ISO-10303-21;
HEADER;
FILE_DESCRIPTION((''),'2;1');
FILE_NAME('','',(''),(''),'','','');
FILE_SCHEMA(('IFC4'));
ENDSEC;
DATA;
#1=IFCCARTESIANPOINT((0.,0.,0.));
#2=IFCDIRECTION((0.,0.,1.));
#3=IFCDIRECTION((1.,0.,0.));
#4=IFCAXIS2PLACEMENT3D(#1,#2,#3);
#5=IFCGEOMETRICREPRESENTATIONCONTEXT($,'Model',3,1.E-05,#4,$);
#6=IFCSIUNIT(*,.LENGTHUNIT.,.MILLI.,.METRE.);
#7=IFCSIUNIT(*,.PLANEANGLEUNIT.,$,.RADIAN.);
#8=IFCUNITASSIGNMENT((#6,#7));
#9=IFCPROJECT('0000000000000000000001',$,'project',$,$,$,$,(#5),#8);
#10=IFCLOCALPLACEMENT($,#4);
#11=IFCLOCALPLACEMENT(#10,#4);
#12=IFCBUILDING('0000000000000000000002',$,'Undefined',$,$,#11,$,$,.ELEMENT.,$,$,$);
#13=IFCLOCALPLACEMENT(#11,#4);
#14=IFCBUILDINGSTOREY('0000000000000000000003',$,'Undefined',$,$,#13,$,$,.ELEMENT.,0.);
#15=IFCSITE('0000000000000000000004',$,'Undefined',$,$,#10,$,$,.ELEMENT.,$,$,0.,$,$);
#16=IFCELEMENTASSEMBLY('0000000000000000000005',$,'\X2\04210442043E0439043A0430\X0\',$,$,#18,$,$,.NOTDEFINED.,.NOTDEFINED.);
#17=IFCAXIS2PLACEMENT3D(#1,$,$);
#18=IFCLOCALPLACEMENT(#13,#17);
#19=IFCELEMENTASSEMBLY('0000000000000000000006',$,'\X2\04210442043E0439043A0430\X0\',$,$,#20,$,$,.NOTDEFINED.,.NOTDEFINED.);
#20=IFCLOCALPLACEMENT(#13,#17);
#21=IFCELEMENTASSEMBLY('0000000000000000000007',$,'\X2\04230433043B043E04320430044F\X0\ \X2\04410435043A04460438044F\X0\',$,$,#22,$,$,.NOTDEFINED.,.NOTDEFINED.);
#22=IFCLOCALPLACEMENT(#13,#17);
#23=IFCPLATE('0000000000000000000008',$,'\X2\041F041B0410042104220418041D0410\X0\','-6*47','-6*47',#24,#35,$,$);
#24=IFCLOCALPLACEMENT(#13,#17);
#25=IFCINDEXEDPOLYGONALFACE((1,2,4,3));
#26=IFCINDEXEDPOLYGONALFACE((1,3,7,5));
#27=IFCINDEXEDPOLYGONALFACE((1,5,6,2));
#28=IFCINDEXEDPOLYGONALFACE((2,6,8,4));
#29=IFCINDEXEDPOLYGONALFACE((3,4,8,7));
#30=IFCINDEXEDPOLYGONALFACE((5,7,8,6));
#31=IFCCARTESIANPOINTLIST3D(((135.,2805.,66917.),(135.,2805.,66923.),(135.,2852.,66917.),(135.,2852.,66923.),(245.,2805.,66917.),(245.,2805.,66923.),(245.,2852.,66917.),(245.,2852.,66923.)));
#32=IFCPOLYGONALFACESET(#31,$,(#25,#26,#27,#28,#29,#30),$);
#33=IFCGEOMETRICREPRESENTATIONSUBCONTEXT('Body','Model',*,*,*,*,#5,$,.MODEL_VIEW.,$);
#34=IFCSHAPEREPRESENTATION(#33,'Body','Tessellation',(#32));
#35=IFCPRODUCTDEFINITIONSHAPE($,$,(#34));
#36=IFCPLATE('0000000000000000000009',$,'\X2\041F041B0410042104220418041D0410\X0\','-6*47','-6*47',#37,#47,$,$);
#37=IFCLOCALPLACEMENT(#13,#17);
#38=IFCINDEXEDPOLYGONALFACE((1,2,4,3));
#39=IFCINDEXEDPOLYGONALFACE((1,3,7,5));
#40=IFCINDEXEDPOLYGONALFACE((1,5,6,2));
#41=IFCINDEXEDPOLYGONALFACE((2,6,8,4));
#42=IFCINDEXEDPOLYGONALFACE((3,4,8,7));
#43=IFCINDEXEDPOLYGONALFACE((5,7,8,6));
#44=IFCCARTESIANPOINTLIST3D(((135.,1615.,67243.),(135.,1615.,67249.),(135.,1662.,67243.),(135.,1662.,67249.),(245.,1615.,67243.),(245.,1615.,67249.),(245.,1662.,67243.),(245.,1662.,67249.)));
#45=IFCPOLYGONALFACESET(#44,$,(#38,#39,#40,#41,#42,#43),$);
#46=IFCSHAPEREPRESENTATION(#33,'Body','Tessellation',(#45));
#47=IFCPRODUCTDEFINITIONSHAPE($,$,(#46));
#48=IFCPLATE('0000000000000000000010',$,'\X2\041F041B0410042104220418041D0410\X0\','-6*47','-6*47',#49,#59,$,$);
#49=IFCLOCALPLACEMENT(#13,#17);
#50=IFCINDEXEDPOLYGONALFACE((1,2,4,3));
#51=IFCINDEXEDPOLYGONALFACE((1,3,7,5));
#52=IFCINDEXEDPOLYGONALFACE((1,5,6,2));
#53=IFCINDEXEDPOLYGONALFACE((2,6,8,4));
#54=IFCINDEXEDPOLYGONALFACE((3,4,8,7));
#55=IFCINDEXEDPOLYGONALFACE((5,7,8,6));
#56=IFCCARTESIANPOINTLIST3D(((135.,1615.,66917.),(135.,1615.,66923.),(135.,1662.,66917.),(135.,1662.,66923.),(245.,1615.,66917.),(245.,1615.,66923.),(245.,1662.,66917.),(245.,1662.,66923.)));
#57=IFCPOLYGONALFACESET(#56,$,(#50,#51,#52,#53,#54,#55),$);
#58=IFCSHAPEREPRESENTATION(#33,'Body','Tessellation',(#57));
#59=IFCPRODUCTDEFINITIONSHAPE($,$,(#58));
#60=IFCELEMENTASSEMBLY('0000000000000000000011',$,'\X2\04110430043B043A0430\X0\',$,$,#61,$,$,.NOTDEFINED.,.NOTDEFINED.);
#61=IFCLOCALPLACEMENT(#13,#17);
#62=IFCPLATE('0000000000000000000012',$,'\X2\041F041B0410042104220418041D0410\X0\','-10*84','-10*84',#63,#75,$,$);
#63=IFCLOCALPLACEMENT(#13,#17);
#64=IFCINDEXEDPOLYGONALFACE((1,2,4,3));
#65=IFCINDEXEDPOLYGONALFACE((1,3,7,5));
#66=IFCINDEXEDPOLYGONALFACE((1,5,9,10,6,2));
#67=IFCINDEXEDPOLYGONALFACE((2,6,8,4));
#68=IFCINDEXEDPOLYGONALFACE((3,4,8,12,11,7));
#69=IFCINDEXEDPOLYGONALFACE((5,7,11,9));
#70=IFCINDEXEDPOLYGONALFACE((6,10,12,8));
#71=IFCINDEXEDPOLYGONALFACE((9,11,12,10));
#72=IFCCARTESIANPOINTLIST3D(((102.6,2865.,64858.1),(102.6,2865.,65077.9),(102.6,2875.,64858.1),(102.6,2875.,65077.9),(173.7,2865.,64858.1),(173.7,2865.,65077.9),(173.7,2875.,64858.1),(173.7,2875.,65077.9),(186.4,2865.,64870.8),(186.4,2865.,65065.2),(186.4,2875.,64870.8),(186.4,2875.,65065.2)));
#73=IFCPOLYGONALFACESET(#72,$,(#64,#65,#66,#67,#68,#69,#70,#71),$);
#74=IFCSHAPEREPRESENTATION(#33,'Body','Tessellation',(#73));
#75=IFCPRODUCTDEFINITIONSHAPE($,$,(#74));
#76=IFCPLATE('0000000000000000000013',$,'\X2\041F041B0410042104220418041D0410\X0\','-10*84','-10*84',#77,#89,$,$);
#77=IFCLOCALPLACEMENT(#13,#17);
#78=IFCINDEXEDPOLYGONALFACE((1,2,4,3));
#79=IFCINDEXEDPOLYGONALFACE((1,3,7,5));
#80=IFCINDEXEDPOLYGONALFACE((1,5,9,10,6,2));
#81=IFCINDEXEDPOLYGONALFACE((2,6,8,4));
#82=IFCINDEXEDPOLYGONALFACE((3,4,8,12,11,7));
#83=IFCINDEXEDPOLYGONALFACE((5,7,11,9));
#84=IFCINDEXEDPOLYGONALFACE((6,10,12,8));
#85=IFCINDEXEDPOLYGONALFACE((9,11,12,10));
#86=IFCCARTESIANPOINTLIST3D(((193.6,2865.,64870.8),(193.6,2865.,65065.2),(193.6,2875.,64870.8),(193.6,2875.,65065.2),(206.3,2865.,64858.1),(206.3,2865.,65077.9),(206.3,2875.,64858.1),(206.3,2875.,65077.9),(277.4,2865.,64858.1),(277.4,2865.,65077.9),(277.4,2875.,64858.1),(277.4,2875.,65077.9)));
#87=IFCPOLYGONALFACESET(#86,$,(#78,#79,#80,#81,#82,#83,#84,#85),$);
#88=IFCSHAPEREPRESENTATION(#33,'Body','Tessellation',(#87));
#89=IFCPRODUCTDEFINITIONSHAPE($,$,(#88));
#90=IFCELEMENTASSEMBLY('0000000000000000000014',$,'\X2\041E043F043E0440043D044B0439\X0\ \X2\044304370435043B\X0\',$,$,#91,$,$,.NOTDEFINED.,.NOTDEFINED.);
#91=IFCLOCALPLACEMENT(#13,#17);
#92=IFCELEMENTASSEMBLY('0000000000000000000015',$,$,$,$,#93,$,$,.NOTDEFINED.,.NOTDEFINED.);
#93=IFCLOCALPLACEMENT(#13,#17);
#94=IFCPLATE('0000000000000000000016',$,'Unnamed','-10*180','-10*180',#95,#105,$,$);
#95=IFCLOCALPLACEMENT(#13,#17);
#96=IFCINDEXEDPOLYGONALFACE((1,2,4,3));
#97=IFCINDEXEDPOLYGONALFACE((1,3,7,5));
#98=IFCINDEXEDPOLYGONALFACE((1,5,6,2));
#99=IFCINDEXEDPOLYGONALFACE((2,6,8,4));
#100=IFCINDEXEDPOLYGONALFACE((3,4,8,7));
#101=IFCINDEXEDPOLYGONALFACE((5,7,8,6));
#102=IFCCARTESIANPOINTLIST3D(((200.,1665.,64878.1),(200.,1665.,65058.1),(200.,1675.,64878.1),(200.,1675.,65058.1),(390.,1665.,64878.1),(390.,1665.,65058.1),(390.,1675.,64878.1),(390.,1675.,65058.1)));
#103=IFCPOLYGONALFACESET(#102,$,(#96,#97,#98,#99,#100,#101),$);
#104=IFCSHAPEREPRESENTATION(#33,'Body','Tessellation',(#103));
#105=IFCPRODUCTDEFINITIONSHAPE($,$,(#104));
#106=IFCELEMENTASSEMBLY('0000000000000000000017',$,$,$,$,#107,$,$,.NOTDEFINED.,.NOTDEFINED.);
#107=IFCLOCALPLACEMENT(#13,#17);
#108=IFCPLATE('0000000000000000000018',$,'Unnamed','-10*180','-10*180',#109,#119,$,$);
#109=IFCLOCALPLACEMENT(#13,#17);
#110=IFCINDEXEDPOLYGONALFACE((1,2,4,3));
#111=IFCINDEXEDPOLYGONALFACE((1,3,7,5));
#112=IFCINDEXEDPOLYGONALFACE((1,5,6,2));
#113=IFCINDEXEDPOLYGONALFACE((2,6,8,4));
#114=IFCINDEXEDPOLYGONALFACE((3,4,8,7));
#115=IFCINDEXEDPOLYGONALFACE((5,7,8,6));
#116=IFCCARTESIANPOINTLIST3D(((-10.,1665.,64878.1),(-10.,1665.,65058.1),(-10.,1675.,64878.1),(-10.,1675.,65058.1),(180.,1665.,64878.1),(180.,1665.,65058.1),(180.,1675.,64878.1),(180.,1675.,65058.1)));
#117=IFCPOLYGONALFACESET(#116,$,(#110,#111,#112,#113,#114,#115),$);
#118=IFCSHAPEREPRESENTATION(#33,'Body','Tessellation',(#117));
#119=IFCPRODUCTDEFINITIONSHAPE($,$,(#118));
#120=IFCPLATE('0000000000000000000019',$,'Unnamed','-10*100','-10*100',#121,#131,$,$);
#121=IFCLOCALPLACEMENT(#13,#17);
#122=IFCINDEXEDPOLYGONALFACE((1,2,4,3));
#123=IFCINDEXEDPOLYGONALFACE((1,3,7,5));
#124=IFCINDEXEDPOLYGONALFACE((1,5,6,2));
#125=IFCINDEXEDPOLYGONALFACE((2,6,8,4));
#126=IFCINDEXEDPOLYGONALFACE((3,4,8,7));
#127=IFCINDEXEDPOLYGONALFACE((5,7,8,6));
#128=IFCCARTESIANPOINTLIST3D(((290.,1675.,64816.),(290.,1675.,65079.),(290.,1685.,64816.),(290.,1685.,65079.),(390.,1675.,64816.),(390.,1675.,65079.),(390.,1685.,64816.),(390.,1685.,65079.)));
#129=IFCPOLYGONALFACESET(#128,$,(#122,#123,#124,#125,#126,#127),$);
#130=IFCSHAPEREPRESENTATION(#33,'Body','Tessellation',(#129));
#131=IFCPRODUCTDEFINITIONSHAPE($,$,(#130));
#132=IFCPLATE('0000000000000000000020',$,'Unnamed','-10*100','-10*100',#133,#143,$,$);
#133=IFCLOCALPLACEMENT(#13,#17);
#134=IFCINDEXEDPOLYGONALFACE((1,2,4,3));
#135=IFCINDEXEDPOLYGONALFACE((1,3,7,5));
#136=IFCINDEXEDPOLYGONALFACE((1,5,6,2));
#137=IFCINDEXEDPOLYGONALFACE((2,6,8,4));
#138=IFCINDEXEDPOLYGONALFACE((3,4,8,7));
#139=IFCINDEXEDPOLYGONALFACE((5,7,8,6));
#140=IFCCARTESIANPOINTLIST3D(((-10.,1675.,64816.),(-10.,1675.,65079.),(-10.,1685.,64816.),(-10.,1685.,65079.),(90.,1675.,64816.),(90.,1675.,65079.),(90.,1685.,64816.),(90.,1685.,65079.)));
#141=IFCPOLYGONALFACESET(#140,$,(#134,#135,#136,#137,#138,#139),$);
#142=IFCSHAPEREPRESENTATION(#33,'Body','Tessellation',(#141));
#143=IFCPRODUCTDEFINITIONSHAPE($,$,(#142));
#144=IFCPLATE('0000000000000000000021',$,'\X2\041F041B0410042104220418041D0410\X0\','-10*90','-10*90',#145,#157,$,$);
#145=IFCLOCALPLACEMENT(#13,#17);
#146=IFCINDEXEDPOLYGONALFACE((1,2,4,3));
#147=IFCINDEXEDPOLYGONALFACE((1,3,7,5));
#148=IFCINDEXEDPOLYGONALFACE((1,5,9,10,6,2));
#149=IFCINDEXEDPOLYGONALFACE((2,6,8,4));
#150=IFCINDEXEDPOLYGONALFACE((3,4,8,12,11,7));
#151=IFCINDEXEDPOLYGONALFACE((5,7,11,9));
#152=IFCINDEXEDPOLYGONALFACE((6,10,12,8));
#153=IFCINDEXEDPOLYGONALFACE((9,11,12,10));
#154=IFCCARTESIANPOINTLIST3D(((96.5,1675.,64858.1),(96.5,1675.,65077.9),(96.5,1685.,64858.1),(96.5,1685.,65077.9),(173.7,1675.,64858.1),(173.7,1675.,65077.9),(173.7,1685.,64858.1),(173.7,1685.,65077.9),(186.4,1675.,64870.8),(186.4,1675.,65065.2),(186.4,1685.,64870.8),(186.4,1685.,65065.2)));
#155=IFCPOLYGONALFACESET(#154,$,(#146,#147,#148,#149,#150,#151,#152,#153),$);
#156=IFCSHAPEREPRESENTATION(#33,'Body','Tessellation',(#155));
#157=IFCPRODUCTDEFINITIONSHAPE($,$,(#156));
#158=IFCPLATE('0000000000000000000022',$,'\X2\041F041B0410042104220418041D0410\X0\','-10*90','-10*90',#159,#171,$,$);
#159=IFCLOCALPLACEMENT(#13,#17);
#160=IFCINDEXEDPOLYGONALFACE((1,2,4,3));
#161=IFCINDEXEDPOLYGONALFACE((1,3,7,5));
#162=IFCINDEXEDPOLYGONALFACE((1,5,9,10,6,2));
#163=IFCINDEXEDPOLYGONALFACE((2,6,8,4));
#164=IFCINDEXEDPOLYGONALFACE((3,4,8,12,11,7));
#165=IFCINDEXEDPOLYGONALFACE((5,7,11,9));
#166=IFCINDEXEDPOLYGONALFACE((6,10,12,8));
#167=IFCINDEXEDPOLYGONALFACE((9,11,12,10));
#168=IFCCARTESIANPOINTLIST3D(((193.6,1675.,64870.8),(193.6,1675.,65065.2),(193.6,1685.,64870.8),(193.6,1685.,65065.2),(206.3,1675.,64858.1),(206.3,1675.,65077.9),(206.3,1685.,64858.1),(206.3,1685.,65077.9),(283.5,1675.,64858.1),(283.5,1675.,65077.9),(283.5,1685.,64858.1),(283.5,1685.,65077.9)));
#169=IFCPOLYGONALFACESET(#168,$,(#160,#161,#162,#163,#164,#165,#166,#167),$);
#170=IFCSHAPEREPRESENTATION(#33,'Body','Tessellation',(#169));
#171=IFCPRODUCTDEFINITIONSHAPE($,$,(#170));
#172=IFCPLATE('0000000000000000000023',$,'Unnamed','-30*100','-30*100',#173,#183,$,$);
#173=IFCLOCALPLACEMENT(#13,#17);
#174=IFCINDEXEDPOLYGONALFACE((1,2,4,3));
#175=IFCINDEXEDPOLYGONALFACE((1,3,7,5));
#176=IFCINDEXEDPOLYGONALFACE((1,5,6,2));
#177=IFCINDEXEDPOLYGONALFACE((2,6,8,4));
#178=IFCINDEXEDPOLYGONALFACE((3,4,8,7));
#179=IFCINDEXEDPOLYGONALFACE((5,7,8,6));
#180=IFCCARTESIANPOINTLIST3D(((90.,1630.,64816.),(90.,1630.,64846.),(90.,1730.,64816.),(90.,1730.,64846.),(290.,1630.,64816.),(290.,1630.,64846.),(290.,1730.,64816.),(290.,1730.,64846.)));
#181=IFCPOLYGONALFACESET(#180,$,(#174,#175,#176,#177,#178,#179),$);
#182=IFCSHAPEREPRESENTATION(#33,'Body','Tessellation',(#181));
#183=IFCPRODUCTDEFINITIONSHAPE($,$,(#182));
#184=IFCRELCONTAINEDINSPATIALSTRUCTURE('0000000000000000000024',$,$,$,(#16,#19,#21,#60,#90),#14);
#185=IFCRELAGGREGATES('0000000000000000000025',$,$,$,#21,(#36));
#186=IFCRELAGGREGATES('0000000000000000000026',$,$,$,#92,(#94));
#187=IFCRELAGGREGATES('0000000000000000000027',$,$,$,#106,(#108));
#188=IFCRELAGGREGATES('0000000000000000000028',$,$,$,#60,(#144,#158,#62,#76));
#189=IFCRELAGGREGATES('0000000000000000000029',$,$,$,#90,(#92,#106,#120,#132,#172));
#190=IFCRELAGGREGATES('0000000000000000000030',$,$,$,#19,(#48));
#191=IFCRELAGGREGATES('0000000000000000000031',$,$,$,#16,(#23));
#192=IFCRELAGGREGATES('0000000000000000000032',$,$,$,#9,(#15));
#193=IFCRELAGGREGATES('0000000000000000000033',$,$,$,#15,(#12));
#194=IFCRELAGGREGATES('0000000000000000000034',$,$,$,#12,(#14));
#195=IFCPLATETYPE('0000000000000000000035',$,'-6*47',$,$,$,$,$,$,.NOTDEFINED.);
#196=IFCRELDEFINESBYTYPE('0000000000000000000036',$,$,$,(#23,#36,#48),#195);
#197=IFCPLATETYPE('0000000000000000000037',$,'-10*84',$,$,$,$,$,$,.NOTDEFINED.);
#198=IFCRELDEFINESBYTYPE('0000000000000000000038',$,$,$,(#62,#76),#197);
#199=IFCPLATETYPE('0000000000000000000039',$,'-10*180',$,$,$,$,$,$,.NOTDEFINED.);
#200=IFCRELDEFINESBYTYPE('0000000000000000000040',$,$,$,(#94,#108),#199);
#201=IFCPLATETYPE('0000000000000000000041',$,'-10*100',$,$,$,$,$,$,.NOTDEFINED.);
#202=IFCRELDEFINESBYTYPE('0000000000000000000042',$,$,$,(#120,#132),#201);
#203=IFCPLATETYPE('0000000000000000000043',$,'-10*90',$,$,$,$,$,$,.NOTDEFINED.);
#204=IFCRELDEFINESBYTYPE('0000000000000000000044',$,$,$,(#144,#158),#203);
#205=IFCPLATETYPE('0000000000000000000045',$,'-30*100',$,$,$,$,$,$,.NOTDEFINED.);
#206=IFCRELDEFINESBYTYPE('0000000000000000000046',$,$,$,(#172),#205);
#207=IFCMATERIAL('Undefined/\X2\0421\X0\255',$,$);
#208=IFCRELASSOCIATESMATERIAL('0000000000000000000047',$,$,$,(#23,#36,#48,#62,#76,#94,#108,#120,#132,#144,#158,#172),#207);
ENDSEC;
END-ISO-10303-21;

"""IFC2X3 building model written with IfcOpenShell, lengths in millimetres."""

from ifc_helpers import new_model, si_unit, frame, origin_with_axes, origin_2d_with_axis, place, context, subcontext, project, spatial, polyline, rectangle, outline, extrude, boolean, material, type_object, element, aggregate, save


model = new_model("IFC2X3")

# Units and contexts
model_context = context("Model", 3, precision=1e-05, world=origin_with_axes())
body_context = subcontext(model_context, "Body", "Model", "MODEL_VIEW")
ifc_project = project(units=[si_unit("LENGTHUNIT", "METRE", prefix="MILLI"), si_unit("PLANEANGLEUNIT", "RADIAN")], contexts=[model_context])

# Site, building, storey
site_placement = place(None, origin_with_axes())
site = spatial("IfcSite", under=ifc_project, at=site_placement, Name="Undefined", CompositionType="ELEMENT", RefElevation=0.0)
building_placement = place(site_placement, origin_with_axes())
building = spatial("IfcBuilding", under=site, at=building_placement, Name="Undefined", CompositionType="ELEMENT")
storey_placement = place(building_placement, origin_with_axes())
storey = spatial("IfcBuildingStorey", under=building, at=storey_placement, Name="Undefined", CompositionType="ELEMENT", Elevation=0.0)

# Element assemblies
assembly_1_placement = place(storey_placement, origin_with_axes())
assembly_1 = element("IfcElementAssembly", 1, at=assembly_1_placement, inside=storey, Name="Стойка", AssemblyPlace="NOTDEFINED", PredefinedType="NOTDEFINED")
ifc_material_1 = material(Name="Undefined/С255")
assembly_2_placement = place(storey_placement, origin_with_axes())
assembly_2 = element("IfcElementAssembly", 2, at=assembly_2_placement, inside=storey, Name="Стойка", AssemblyPlace="NOTDEFINED", PredefinedType="NOTDEFINED")

# Element assembly
assembly_3_placement = place(storey_placement, origin_with_axes())
assembly_3 = element("IfcElementAssembly", 3, at=assembly_3_placement, inside=storey, Name="Угловая секция", AssemblyPlace="NOTDEFINED", PredefinedType="NOTDEFINED")

# Plates
plate_type_1 = type_object("IfcPlateType", Name="-6*47", PredefinedType="NOTDEFINED")
plate_1_placement = place(assembly_1_placement, frame((135.0, 2805.0, 66920.0), z_axis=(0.0, 0.0, 1.0), x_axis=(1.0, 0.0, 0.0)))
plate_1 = element("IfcPlate", 4, at=plate_1_placement, type_object=plate_type_1, material=ifc_material_1, Name="ПЛАСТИНА", Description="-6*47", ObjectType="-6*47", context=body_context, shape_type="CSG", body=[
    boolean("DIFFERENCE", extrude(outline(polyline([(0.0, 0.0), (110.0, 0.0), (110.0, 110.0), (0.0, 110.0), (0.0, 0.0)])), frame((0.0, 0.0, -3.0), z_axis=(0.0, 0.0, 1.0), x_axis=(1.0, 0.0, 0.0)), (0.0, 0.0, 1.0), 6.0), extrude(rectangle(XDim=26.0, YDim=130.0, at=origin_2d_with_axis()), frame((55.0, 47.0, 0.0), z_axis=(0.0, 1.0, 0.0), x_axis=(0.0, 0.0, -1.0)), (0.0, 0.0, 1.0), 66.0)),
])
plate_2_placement = place(assembly_3_placement, frame((245.0, 1615.0, 67246.0), z_axis=(0.0, 0.0, -1.0), x_axis=(-1.0, 0.0, 0.0)))
plate_2 = element("IfcPlate", 5, at=plate_2_placement, type_object=plate_type_1, material=ifc_material_1, Name="ПЛАСТИНА", Description="-6*47", ObjectType="-6*47", context=body_context, shape_type="CSG", body=[
    boolean("DIFFERENCE", extrude(outline(polyline([(0.0, 0.0), (110.0, 0.0), (110.0, 110.0), (0.0, 110.0), (0.0, 0.0)])), frame((0.0, 0.0, -3.0), z_axis=(0.0, 0.0, 1.0), x_axis=(1.0, 0.0, 0.0)), (0.0, 0.0, 1.0), 6.0), extrude(rectangle(XDim=26.0, YDim=130.0, at=origin_2d_with_axis()), frame((55.0, 47.0, 0.0), z_axis=(0.0, 1.0, 0.0), x_axis=(0.0, 0.0, -1.0)), (0.0, 0.0, 1.0), 66.0)),
])
aggregate(assembly_3, [plate_2])
plate_3_placement = place(assembly_2_placement, frame((135.0, 1615.0, 66920.0), z_axis=(0.0, 0.0, 1.0), x_axis=(1.0, 0.0, 0.0)))
plate_3 = element("IfcPlate", 6, at=plate_3_placement, type_object=plate_type_1, material=ifc_material_1, Name="ПЛАСТИНА", Description="-6*47", ObjectType="-6*47", context=body_context, shape_type="CSG", body=[
    boolean("DIFFERENCE", extrude(outline(polyline([(0.0, 0.0), (110.0, 0.0), (110.0, 110.0), (0.0, 110.0), (0.0, 0.0)])), frame((0.0, 0.0, -3.0), z_axis=(0.0, 0.0, 1.0), x_axis=(1.0, 0.0, 0.0)), (0.0, 0.0, 1.0), 6.0), extrude(rectangle(XDim=26.0, YDim=130.0, at=origin_2d_with_axis()), frame((55.0, 47.0, 0.0), z_axis=(0.0, 1.0, 0.0), x_axis=(0.0, 0.0, -1.0)), (0.0, 0.0, 1.0), 66.0)),
])

# Element assembly, plates
assembly_4_placement = place(storey_placement, origin_with_axes())
assembly_4 = element("IfcElementAssembly", 7, at=assembly_4_placement, inside=storey, Name="Балка", AssemblyPlace="NOTDEFINED", PredefinedType="NOTDEFINED")
plate_type_2 = type_object("IfcPlateType", Name="-10*84", PredefinedType="NOTDEFINED")
plate_4_placement = place(assembly_4_placement, frame((186.4, 2870.0, 65077.9), z_axis=(0.0, -1.0, 0.0), x_axis=(-1.0, 0.0, 0.0)))
plate_4 = element("IfcPlate", 8, at=plate_4_placement, type_object=plate_type_2, material=ifc_material_1, Name="ПЛАСТИНА", Description="-10*84", ObjectType="-10*84", context=body_context, shape_type="SweptSolid", body=[
    extrude(outline(polyline([(0.0, 12.7), (12.7, 0.0), (83.8, 0.0), (83.8, 219.8), (12.7, 219.8), (0.0, 207.1), (0.0, 12.7)])), frame((0.0, 0.0, -5.0), z_axis=(0.0, 0.0, 1.0), x_axis=(1.0, 0.0, 0.0)), (0.0, 0.0, 1.0), 10.0),
])
plate_5_placement = place(assembly_4_placement, frame((277.4, 2870.0, 65077.9), z_axis=(0.0, -1.0, 0.0), x_axis=(-1.0, 0.0, 0.0)))
plate_5 = element("IfcPlate", 9, at=plate_5_placement, type_object=plate_type_2, material=ifc_material_1, Name="ПЛАСТИНА", Description="-10*84", ObjectType="-10*84", context=body_context, shape_type="SweptSolid", body=[
    extrude(outline(polyline([(0.0, 0.0), (71.1, 0.0), (83.8, 12.7), (83.8, 207.1), (71.1, 219.8), (0.0, 219.8), (0.0, 0.0)])), frame((0.0, 0.0, -5.0), z_axis=(0.0, 0.0, 1.0), x_axis=(1.0, 0.0, 0.0)), (0.0, 0.0, 1.0), 10.0),
])

# Element assemblies, plates
assembly_5_placement = place(storey_placement, origin_with_axes())
assembly_5 = element("IfcElementAssembly", 10, at=assembly_5_placement, inside=storey, Name="Опорный узел", AssemblyPlace="NOTDEFINED", PredefinedType="NOTDEFINED")
assembly_6_placement = place(assembly_5_placement, origin_with_axes())
assembly_6 = element("IfcElementAssembly", 11, at=assembly_6_placement, AssemblyPlace="NOTDEFINED", PredefinedType="NOTDEFINED")
plate_type_3 = type_object("IfcPlateType", Name="-10*180", PredefinedType="NOTDEFINED")
plate_6_placement = place(assembly_6_placement, frame((390.0, 1670.0, 65058.1), z_axis=(0.0, -1.0, 0.0), x_axis=(-1.0, 0.0, 0.0)))
plate_6 = element("IfcPlate", 12, at=plate_6_placement, type_object=plate_type_3, material=ifc_material_1, Name="Unnamed", Description="-10*180", ObjectType="-10*180", context=body_context, shape_type="SweptSolid", body=[
    extrude(outline(polyline([(0.0, 0.0), (190.0, 0.0), (190.0, 180.0), (0.0, 180.0), (0.0, 0.0)])), frame((0.0, 0.0, -5.0), z_axis=(0.0, 0.0, 1.0), x_axis=(1.0, 0.0, 0.0)), (0.0, 0.0, 1.0), 10.0),
])
aggregate(assembly_6, [plate_6])
assembly_7_placement = place(assembly_5_placement, origin_with_axes())
assembly_7 = element("IfcElementAssembly", 13, at=assembly_7_placement, AssemblyPlace="NOTDEFINED", PredefinedType="NOTDEFINED")
plate_7_placement = place(assembly_7_placement, frame((180.0, 1670.0, 65058.1), z_axis=(0.0, -1.0, 0.0), x_axis=(-1.0, 0.0, 0.0)))
plate_7 = element("IfcPlate", 14, at=plate_7_placement, type_object=plate_type_3, material=ifc_material_1, Name="Unnamed", Description="-10*180", ObjectType="-10*180", context=body_context, shape_type="SweptSolid", body=[
    extrude(outline(polyline([(0.0, 0.0), (190.0, 0.0), (190.0, 180.0), (0.0, 180.0), (0.0, 0.0)])), frame((0.0, 0.0, -5.0), z_axis=(0.0, 0.0, 1.0), x_axis=(1.0, 0.0, 0.0)), (0.0, 0.0, 1.0), 10.0),
])
aggregate(assembly_7, [plate_7])
plate_type_4 = type_object("IfcPlateType", Name="-10*100", PredefinedType="NOTDEFINED")
plate_8_placement = place(assembly_5_placement, frame((290.0, 1680.0, 64816.0), z_axis=(0.0, 1.0, 0.0), x_axis=(0.0, 0.0, 1.0)))
plate_8 = element("IfcPlate", 15, at=plate_8_placement, type_object=plate_type_4, material=ifc_material_1, Name="Unnamed", Description="-10*100", ObjectType="-10*100", context=body_context, shape_type="SweptSolid", body=[
    extrude(outline(polyline([(0.0, 0.0), (263.0, 0.0), (263.0, 100.0), (0.0, 100.0), (0.0, 0.0)])), frame((0.0, 0.0, -5.0), z_axis=(0.0, 0.0, 1.0), x_axis=(1.0, 0.0, 0.0)), (0.0, 0.0, 1.0), 10.0),
])
plate_9_placement = place(assembly_5_placement, frame((-10.0, 1680.0, 64816.0), z_axis=(0.0, 1.0, 0.0), x_axis=(0.0, 0.0, 1.0)))
plate_9 = element("IfcPlate", 16, at=plate_9_placement, type_object=plate_type_4, material=ifc_material_1, Name="Unnamed", Description="-10*100", ObjectType="-10*100", context=body_context, shape_type="SweptSolid", body=[
    extrude(outline(polyline([(0.0, 0.0), (263.0, 0.0), (263.0, 100.0), (0.0, 100.0), (0.0, 0.0)])), frame((0.0, 0.0, -5.0), z_axis=(0.0, 0.0, 1.0), x_axis=(1.0, 0.0, 0.0)), (0.0, 0.0, 1.0), 10.0),
])

# Plates
plate_type_5 = type_object("IfcPlateType", Name="-10*90", PredefinedType="NOTDEFINED")
plate_10_placement = place(assembly_4_placement, frame((186.4, 1680.0, 65077.9), z_axis=(0.0, -1.0, 0.0), x_axis=(-1.0, 0.0, 0.0)))
plate_10 = element("IfcPlate", 17, at=plate_10_placement, type_object=plate_type_5, material=ifc_material_1, Name="ПЛАСТИНА", Description="-10*90", ObjectType="-10*90", context=body_context, shape_type="SweptSolid", body=[
    extrude(outline(polyline([(0.0, 12.7), (12.7, 0.0), (89.9, 0.0), (89.9, 219.8), (12.7, 219.8), (0.0, 207.1), (0.0, 12.7)])), frame((0.0, 0.0, -5.0), z_axis=(0.0, 0.0, 1.0), x_axis=(1.0, 0.0, 0.0)), (0.0, 0.0, 1.0), 10.0),
])
plate_11_placement = place(assembly_4_placement, frame((283.5, 1680.0, 65077.9), z_axis=(0.0, -1.0, 0.0), x_axis=(-1.0, 0.0, 0.0)))
plate_11 = element("IfcPlate", 18, at=plate_11_placement, type_object=plate_type_5, material=ifc_material_1, Name="ПЛАСТИНА", Description="-10*90", ObjectType="-10*90", context=body_context, shape_type="SweptSolid", body=[
    extrude(outline(polyline([(0.0, 0.0), (77.2, 0.0), (89.9, 12.7), (89.9, 207.1), (77.2, 219.8), (0.0, 219.8), (0.0, 0.0)])), frame((0.0, 0.0, -5.0), z_axis=(0.0, 0.0, 1.0), x_axis=(1.0, 0.0, 0.0)), (0.0, 0.0, 1.0), 10.0),
])
plate_type_6 = type_object("IfcPlateType", Name="-30*100", PredefinedType="NOTDEFINED")
plate_12_placement = place(assembly_5_placement, frame((290.0, 1730.0, 64831.0), z_axis=(0.0, 0.0, 1.0), x_axis=(-1.0, 0.0, 0.0)))
plate_12 = element("IfcPlate", 19, at=plate_12_placement, type_object=plate_type_6, material=ifc_material_1, Name="Unnamed", Description="-30*100", ObjectType="-30*100", context=body_context, shape_type="SweptSolid", body=[
    extrude(outline(polyline([(0.0, 0.0), (200.0, 0.0), (200.0, 100.0), (0.0, 100.0), (0.0, 0.0)])), frame((0.0, 0.0, -15.0), z_axis=(0.0, 0.0, 1.0), x_axis=(1.0, 0.0, 0.0)), (0.0, 0.0, 1.0), 30.0),
])

aggregate(assembly_4, [plate_10, plate_11, plate_4, plate_5])
aggregate(assembly_5, [assembly_6, assembly_7, plate_8, plate_9, plate_12])

aggregate(assembly_2, [plate_3])
aggregate(assembly_1, [plate_1])

save(model, "model.ifc")
